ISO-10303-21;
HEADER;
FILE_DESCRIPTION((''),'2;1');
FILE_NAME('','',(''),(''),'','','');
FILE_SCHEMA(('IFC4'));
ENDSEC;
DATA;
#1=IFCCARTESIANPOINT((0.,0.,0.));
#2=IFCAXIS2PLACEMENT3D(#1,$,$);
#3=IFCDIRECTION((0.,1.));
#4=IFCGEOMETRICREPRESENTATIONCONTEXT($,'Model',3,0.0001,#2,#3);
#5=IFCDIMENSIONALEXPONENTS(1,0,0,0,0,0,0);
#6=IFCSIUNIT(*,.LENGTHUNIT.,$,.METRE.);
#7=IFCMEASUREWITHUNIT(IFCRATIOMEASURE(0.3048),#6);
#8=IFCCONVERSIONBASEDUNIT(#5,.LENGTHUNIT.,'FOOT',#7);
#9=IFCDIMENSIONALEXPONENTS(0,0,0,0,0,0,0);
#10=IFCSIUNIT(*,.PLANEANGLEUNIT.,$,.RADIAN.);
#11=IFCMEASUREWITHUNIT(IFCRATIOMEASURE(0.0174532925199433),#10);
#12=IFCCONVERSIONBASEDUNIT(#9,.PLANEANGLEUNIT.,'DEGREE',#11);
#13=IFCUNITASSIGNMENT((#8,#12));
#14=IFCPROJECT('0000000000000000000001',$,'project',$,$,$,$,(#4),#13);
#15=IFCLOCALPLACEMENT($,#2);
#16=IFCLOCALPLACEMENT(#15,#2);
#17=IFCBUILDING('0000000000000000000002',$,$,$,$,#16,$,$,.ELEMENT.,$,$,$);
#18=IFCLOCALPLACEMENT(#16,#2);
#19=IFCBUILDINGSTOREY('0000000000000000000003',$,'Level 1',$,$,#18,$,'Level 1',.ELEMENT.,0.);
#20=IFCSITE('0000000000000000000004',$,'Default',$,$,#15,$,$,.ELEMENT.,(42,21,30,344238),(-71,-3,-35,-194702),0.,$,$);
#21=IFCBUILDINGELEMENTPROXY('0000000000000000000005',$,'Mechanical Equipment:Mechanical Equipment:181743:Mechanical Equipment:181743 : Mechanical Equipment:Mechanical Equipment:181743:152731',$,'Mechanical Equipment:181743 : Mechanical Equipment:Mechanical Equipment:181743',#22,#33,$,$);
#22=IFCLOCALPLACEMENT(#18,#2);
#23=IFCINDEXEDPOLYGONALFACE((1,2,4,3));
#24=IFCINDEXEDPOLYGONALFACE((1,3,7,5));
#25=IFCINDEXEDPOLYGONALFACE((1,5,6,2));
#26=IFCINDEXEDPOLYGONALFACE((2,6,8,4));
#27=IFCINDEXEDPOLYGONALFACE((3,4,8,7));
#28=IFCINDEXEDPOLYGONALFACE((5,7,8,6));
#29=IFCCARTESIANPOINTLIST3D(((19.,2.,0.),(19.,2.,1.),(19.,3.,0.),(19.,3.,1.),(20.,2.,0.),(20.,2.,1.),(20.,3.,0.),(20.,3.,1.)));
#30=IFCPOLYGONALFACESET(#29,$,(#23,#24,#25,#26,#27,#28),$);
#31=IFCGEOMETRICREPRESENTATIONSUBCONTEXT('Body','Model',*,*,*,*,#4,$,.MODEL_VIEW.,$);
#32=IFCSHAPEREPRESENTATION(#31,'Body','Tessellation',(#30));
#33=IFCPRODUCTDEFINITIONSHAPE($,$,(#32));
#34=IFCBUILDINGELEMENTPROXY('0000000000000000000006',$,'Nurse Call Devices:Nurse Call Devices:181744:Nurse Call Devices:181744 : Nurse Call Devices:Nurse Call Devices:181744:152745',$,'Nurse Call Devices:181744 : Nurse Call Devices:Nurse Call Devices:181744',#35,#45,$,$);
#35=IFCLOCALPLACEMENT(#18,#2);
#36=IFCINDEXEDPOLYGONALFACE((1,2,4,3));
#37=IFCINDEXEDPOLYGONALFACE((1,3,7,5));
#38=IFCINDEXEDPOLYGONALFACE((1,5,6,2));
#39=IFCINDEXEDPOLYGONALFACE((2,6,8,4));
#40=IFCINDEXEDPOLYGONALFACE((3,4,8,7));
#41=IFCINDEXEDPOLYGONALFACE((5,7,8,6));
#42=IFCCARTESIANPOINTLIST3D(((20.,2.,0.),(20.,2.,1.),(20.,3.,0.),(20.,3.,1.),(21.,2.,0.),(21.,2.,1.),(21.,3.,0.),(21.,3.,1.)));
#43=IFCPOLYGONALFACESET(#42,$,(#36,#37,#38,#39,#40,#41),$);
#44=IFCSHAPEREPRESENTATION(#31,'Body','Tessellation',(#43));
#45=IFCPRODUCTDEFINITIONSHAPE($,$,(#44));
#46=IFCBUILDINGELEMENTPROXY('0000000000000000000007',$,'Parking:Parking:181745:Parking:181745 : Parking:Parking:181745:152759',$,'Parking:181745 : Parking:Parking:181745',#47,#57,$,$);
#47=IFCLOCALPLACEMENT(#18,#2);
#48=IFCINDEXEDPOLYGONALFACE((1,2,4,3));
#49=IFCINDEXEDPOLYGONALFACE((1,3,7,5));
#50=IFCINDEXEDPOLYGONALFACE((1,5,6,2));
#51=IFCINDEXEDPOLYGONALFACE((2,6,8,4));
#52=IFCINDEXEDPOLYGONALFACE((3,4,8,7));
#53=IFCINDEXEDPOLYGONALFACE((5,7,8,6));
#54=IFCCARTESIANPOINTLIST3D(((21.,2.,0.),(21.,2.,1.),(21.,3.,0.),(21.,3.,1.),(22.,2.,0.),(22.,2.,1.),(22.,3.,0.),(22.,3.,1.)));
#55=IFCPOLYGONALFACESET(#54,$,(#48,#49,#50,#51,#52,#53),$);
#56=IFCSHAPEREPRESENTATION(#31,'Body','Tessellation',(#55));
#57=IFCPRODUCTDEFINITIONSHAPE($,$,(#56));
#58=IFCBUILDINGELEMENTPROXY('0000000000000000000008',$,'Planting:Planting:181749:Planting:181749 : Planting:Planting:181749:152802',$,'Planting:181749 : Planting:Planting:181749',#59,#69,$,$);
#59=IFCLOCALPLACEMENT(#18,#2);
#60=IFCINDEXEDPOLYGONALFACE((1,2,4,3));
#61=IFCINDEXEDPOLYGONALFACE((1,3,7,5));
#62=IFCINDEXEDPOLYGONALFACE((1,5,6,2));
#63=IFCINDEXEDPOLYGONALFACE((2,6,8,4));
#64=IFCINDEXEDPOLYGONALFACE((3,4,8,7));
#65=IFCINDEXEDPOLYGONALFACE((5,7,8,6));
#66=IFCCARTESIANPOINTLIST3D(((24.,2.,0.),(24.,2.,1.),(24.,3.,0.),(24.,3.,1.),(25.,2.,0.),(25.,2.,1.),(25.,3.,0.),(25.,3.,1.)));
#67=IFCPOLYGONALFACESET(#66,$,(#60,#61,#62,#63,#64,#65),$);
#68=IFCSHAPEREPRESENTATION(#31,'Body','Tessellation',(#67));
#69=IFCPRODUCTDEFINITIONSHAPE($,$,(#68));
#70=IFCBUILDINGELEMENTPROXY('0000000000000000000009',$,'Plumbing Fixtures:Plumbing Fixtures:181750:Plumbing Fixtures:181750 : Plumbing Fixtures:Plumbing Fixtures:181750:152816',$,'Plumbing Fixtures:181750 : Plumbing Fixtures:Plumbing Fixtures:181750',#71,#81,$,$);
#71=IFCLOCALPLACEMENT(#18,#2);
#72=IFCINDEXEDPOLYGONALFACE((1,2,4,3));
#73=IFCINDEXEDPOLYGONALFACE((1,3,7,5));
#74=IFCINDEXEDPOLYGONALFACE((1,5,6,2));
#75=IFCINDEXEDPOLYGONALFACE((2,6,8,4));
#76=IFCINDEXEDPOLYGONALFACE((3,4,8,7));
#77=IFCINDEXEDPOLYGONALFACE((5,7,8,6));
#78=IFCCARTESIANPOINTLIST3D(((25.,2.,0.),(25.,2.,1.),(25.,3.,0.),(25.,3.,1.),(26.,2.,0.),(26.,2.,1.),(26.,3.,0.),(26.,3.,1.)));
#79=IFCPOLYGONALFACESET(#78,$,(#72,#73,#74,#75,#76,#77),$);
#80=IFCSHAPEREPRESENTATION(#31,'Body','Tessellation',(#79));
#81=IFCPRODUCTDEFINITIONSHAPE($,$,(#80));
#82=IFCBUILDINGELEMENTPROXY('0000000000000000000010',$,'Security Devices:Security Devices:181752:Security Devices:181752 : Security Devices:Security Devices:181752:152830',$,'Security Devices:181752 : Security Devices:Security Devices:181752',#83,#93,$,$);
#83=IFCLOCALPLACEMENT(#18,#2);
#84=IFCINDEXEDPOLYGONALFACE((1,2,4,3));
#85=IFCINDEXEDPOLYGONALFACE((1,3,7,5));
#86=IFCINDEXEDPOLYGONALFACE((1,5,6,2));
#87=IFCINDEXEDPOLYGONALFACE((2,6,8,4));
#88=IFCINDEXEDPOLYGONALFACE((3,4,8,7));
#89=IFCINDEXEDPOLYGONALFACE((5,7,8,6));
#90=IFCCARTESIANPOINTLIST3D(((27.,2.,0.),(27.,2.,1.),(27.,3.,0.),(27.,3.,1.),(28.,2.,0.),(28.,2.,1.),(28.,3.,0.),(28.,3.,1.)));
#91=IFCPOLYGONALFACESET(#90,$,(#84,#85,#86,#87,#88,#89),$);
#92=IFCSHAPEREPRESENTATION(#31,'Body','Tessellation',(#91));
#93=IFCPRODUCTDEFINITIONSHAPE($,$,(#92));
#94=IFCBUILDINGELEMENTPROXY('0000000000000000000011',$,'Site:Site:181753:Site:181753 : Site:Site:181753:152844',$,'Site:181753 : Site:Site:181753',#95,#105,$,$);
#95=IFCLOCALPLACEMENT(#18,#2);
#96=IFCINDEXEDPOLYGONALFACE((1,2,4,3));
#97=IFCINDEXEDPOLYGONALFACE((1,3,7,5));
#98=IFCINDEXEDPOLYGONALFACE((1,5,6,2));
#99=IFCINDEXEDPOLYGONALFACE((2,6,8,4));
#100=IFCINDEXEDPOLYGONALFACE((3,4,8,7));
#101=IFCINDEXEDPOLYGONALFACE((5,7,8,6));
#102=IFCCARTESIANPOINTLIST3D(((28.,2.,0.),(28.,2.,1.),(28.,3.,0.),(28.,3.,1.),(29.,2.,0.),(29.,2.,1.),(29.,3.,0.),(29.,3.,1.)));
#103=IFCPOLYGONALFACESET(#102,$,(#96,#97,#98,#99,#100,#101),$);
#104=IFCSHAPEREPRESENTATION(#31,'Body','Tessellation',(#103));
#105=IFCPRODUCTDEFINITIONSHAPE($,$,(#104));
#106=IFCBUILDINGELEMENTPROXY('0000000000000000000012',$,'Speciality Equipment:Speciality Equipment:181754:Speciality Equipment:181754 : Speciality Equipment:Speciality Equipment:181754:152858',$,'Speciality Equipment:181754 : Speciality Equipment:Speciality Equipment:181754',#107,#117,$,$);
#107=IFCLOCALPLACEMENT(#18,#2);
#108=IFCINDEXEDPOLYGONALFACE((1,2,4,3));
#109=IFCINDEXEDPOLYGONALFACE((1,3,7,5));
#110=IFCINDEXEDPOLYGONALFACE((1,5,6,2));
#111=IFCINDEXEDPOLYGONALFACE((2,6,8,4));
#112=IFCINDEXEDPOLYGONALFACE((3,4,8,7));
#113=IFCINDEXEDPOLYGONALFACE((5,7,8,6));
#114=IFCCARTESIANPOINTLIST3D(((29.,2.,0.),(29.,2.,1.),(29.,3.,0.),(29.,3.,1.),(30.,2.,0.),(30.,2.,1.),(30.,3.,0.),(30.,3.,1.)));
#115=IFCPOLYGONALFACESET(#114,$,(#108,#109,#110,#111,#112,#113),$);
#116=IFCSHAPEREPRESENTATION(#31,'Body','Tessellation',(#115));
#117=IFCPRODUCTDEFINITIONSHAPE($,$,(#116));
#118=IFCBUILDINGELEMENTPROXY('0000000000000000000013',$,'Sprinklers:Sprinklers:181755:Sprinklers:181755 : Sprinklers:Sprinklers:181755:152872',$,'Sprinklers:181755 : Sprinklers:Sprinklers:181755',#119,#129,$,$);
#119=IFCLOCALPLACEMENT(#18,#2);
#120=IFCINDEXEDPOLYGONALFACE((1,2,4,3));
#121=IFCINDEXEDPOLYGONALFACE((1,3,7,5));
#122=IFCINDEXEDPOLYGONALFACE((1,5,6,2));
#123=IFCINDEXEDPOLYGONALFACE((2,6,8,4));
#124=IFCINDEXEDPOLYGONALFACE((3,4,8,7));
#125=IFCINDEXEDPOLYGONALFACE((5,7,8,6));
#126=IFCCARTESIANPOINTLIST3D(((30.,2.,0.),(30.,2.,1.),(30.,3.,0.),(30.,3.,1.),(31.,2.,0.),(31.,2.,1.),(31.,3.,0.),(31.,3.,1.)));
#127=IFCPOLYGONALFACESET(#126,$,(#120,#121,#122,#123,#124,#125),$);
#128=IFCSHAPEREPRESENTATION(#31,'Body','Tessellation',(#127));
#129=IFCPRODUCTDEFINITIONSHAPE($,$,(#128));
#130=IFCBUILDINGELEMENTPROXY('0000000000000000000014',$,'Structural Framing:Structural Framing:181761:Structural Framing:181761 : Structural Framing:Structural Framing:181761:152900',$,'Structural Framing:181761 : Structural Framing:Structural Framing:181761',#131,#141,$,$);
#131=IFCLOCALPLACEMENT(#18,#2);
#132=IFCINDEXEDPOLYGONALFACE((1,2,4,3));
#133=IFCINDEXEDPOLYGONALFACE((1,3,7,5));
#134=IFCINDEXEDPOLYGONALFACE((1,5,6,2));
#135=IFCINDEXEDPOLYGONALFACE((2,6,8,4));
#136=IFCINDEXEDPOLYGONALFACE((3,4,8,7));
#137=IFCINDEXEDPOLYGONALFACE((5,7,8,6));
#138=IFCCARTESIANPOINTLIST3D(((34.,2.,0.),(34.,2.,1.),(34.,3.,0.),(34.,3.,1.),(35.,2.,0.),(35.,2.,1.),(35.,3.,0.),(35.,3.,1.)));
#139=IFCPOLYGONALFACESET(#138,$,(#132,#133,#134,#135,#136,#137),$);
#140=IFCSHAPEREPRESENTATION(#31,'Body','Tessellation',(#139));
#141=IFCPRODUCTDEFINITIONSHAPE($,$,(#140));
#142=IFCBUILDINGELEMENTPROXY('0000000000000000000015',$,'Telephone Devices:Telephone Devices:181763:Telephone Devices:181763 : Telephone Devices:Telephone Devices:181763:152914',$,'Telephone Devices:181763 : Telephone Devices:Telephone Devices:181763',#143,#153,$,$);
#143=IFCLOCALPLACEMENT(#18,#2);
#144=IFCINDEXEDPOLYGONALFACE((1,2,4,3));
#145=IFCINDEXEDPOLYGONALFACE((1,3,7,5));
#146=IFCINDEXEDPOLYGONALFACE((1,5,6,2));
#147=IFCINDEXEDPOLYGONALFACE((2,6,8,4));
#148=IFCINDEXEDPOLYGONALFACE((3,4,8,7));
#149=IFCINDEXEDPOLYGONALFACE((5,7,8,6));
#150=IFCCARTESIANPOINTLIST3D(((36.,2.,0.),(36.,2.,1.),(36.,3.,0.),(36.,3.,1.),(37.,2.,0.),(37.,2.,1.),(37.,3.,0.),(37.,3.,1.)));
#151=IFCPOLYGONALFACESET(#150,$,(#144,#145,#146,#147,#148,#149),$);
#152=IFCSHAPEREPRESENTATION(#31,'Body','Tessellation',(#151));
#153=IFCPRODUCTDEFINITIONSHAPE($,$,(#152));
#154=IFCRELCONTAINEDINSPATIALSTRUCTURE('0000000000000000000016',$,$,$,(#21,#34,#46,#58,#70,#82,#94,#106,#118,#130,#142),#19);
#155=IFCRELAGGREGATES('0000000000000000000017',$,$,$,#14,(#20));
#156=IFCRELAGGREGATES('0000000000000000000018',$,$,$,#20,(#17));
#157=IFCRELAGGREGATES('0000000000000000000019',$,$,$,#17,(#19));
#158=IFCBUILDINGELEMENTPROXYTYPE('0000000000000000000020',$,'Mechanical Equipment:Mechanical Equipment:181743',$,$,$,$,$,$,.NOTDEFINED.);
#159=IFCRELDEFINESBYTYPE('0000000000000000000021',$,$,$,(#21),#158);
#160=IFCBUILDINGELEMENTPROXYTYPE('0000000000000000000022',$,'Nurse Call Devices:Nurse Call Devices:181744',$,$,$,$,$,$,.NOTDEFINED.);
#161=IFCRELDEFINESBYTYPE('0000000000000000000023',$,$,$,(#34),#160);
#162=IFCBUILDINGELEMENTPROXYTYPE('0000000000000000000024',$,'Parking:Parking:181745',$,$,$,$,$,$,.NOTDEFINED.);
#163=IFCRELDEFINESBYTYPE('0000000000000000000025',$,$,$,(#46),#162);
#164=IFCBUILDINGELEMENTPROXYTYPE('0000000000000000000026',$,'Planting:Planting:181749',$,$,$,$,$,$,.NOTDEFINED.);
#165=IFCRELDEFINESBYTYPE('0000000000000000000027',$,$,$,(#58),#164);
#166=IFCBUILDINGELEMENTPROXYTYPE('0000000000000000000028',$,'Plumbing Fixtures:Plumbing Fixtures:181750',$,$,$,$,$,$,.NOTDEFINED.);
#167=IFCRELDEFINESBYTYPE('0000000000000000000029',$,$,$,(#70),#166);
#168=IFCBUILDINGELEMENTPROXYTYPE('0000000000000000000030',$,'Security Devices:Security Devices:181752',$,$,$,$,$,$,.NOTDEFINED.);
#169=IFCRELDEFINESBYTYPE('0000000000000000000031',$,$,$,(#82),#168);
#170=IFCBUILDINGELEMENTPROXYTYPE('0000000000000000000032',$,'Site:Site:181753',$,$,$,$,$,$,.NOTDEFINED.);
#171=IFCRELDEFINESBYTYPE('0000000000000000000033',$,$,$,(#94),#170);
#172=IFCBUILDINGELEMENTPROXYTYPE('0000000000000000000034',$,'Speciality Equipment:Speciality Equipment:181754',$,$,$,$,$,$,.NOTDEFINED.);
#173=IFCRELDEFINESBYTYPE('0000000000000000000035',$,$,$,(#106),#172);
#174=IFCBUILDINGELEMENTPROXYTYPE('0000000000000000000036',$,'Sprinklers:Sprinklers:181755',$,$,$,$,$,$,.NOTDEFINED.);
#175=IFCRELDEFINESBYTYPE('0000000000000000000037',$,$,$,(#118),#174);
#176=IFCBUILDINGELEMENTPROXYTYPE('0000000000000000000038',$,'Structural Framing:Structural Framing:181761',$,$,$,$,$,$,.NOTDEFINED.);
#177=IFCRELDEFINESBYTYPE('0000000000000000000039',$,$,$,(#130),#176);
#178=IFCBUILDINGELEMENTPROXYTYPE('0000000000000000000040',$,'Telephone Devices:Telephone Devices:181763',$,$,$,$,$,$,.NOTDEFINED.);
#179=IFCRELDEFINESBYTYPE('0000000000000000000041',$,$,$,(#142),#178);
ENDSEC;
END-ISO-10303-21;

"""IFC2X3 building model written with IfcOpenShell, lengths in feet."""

from ifc_helpers import new_model, entity, si_unit, converted_unit, direction, frame, frame_2d, origin, place, context, subcontext, project, spatial, rectangle, extrude, source, transform, mapped, type_object, type_shapes, element, save


model = new_model("IFC2X3")

# Units and contexts
model_context = context("Model", 3, precision=0.0001, world=origin(), true_north=direction((0.0, 1.0)))
body_context = subcontext(model_context, "Body", "Model", "MODEL_VIEW")
ifc_project = project(units=[converted_unit("LENGTHUNIT", "FOOT", entity("IfcRatioMeasure", 0.3048), si_unit("LENGTHUNIT", "METRE"), dimensions=[1, 0, 0, 0, 0, 0, 0]), converted_unit("PLANEANGLEUNIT", "DEGREE", entity("IfcRatioMeasure", 0.0174532925199433), si_unit("PLANEANGLEUNIT", "RADIAN"), dimensions=[0, 0, 0, 0, 0, 0, 0])], contexts=[model_context])

# Site, building, storey
site_placement = place(None, origin())
site = spatial("IfcSite", under=ifc_project, at=site_placement, Name="Default", CompositionType="ELEMENT", RefLatitude=(42, 21, 30, 344238), RefLongitude=(-71, -3, -35, -194702), RefElevation=0.0)
building_placement = place(site_placement, origin())
building = spatial("IfcBuilding", under=site, at=building_placement, CompositionType="ELEMENT")
storey_placement = place(building_placement, origin())
storey = spatial("IfcBuildingStorey", under=building, at=storey_placement, Name="Level 1", LongName="Level 1", CompositionType="ELEMENT", Elevation=0.0)

# Building element proxies
building_element_proxy_type_1 = type_object("IfcBuildingElementProxyType", Name="Mechanical Equipment:Mechanical Equipment:181743", PredefinedType="NOTDEFINED")
shared_shape_1 = source(origin(), body_context, "Body", "SweptSolid", [
    extrude(rectangle(XDim=1.0, YDim=1.0, at=frame_2d((0.0, 0.0), x_axis=(1.0, 0.0))), frame((19.5, 2.5, 0.0), z_axis=(0.0, 0.0, 1.0), x_axis=(-1.0, 0.0, 0.0)), (0.0, 0.0, 1.0), 1.0),
])
type_shapes(building_element_proxy_type_1, [shared_shape_1])
proxy_1_placement = place(storey_placement, origin())
element("IfcBuildingElementProxy", 1, at=proxy_1_placement, inside=storey, type_object=building_element_proxy_type_1, Name="Mechanical Equipment:Mechanical Equipment:181743:Mechanical Equipment:181743 : Mechanical Equipment:Mechanical Equipment:181743:152731", ObjectType="Mechanical Equipment:181743 : Mechanical Equipment:Mechanical Equipment:181743", context=body_context, shape_type="MappedRepresentation", body=[
    mapped(shared_shape_1, transform((0.0, 0.0, 0.0), scale=1.0)),
])
building_element_proxy_type_2 = type_object("IfcBuildingElementProxyType", Name="Nurse Call Devices:Nurse Call Devices:181744", PredefinedType="NOTDEFINED")
shared_shape_2 = source(origin(), body_context, "Body", "SweptSolid", [
    extrude(rectangle(XDim=1.0, YDim=1.0, at=frame_2d((0.0, 0.0), x_axis=(1.0, 0.0))), frame((20.5, 2.5, 0.0), z_axis=(0.0, 0.0, 1.0), x_axis=(-1.0, 0.0, 0.0)), (0.0, 0.0, 1.0), 1.0),
])
type_shapes(building_element_proxy_type_2, [shared_shape_2])
proxy_2_placement = place(storey_placement, origin())
element("IfcBuildingElementProxy", 2, at=proxy_2_placement, inside=storey, type_object=building_element_proxy_type_2, Name="Nurse Call Devices:Nurse Call Devices:181744:Nurse Call Devices:181744 : Nurse Call Devices:Nurse Call Devices:181744:152745", ObjectType="Nurse Call Devices:181744 : Nurse Call Devices:Nurse Call Devices:181744", context=body_context, shape_type="MappedRepresentation", body=[
    mapped(shared_shape_2, transform((0.0, 0.0, 0.0), scale=1.0)),
])
building_element_proxy_type_3 = type_object("IfcBuildingElementProxyType", Name="Parking:Parking:181745", PredefinedType="NOTDEFINED")
shared_shape_3 = source(origin(), body_context, "Body", "SweptSolid", [
    extrude(rectangle(XDim=1.0, YDim=1.0, at=frame_2d((0.0, 0.0), x_axis=(1.0, 0.0))), frame((21.5, 2.5, 0.0), z_axis=(0.0, 0.0, 1.0), x_axis=(-1.0, 0.0, 0.0)), (0.0, 0.0, 1.0), 1.0),
])
type_shapes(building_element_proxy_type_3, [shared_shape_3])
proxy_3_placement = place(storey_placement, origin())
element("IfcBuildingElementProxy", 3, at=proxy_3_placement, inside=storey, type_object=building_element_proxy_type_3, Name="Parking:Parking:181745:Parking:181745 : Parking:Parking:181745:152759", ObjectType="Parking:181745 : Parking:Parking:181745", context=body_context, shape_type="MappedRepresentation", body=[
    mapped(shared_shape_3, transform((0.0, 0.0, 0.0), scale=1.0)),
])
building_element_proxy_type_4 = type_object("IfcBuildingElementProxyType", Name="Planting:Planting:181749", PredefinedType="NOTDEFINED")
shared_shape_4 = source(origin(), body_context, "Body", "SweptSolid", [
    extrude(rectangle(XDim=1.0, YDim=1.0, at=frame_2d((0.0, 0.0), x_axis=(1.0, 0.0))), frame((24.5, 2.5, 0.0), z_axis=(0.0, 0.0, 1.0), x_axis=(-1.0, 0.0, 0.0)), (0.0, 0.0, 1.0), 1.0),
])
type_shapes(building_element_proxy_type_4, [shared_shape_4])
proxy_4_placement = place(storey_placement, origin())
element("IfcBuildingElementProxy", 4, at=proxy_4_placement, inside=storey, type_object=building_element_proxy_type_4, Name="Planting:Planting:181749:Planting:181749 : Planting:Planting:181749:152802", ObjectType="Planting:181749 : Planting:Planting:181749", context=body_context, shape_type="MappedRepresentation", body=[
    mapped(shared_shape_4, transform((0.0, 0.0, 0.0), scale=1.0)),
])
building_element_proxy_type_5 = type_object("IfcBuildingElementProxyType", Name="Plumbing Fixtures:Plumbing Fixtures:181750", PredefinedType="NOTDEFINED")
shared_shape_5 = source(origin(), body_context, "Body", "SweptSolid", [
    extrude(rectangle(XDim=1.0, YDim=1.0, at=frame_2d((0.0, 0.0), x_axis=(1.0, 0.0))), frame((25.5, 2.5, 0.0), z_axis=(0.0, 0.0, 1.0), x_axis=(-1.0, 0.0, 0.0)), (0.0, 0.0, 1.0), 1.0),
])
type_shapes(building_element_proxy_type_5, [shared_shape_5])
proxy_5_placement = place(storey_placement, origin())
element("IfcBuildingElementProxy", 5, at=proxy_5_placement, inside=storey, type_object=building_element_proxy_type_5, Name="Plumbing Fixtures:Plumbing Fixtures:181750:Plumbing Fixtures:181750 : Plumbing Fixtures:Plumbing Fixtures:181750:152816", ObjectType="Plumbing Fixtures:181750 : Plumbing Fixtures:Plumbing Fixtures:181750", context=body_context, shape_type="MappedRepresentation", body=[
    mapped(shared_shape_5, transform((0.0, 0.0, 0.0), scale=1.0)),
])
building_element_proxy_type_6 = type_object("IfcBuildingElementProxyType", Name="Security Devices:Security Devices:181752", PredefinedType="NOTDEFINED")
shared_shape_6 = source(origin(), body_context, "Body", "SweptSolid", [
    extrude(rectangle(XDim=1.0, YDim=1.0, at=frame_2d((0.0, 0.0), x_axis=(1.0, 0.0))), frame((27.5, 2.5, 0.0), z_axis=(0.0, 0.0, 1.0), x_axis=(-1.0, 0.0, 0.0)), (0.0, 0.0, 1.0), 1.0),
])
type_shapes(building_element_proxy_type_6, [shared_shape_6])
proxy_6_placement = place(storey_placement, origin())
element("IfcBuildingElementProxy", 6, at=proxy_6_placement, inside=storey, type_object=building_element_proxy_type_6, Name="Security Devices:Security Devices:181752:Security Devices:181752 : Security Devices:Security Devices:181752:152830", ObjectType="Security Devices:181752 : Security Devices:Security Devices:181752", context=body_context, shape_type="MappedRepresentation", body=[
    mapped(shared_shape_6, transform((0.0, 0.0, 0.0), scale=1.0)),
])
building_element_proxy_type_7 = type_object("IfcBuildingElementProxyType", Name="Site:Site:181753", PredefinedType="NOTDEFINED")
shared_shape_7 = source(origin(), body_context, "Body", "SweptSolid", [
    extrude(rectangle(XDim=1.0, YDim=1.0, at=frame_2d((0.0, 0.0), x_axis=(1.0, 0.0))), frame((28.5, 2.5, 0.0), z_axis=(0.0, 0.0, 1.0), x_axis=(-1.0, 0.0, 0.0)), (0.0, 0.0, 1.0), 1.0),
])
type_shapes(building_element_proxy_type_7, [shared_shape_7])
proxy_7_placement = place(storey_placement, origin())
element("IfcBuildingElementProxy", 7, at=proxy_7_placement, inside=storey, type_object=building_element_proxy_type_7, Name="Site:Site:181753:Site:181753 : Site:Site:181753:152844", ObjectType="Site:181753 : Site:Site:181753", context=body_context, shape_type="MappedRepresentation", body=[
    mapped(shared_shape_7, transform((0.0, 0.0, 0.0), scale=1.0)),
])
building_element_proxy_type_8 = type_object("IfcBuildingElementProxyType", Name="Speciality Equipment:Speciality Equipment:181754", PredefinedType="NOTDEFINED")
shared_shape_8 = source(origin(), body_context, "Body", "SweptSolid", [
    extrude(rectangle(XDim=1.0, YDim=1.0, at=frame_2d((0.0, 0.0), x_axis=(1.0, 0.0))), frame((29.5, 2.5, 0.0), z_axis=(0.0, 0.0, 1.0), x_axis=(-1.0, 0.0, 0.0)), (0.0, 0.0, 1.0), 1.0),
])
type_shapes(building_element_proxy_type_8, [shared_shape_8])
proxy_8_placement = place(storey_placement, origin())
element("IfcBuildingElementProxy", 8, at=proxy_8_placement, inside=storey, type_object=building_element_proxy_type_8, Name="Speciality Equipment:Speciality Equipment:181754:Speciality Equipment:181754 : Speciality Equipment:Speciality Equipment:181754:152858", ObjectType="Speciality Equipment:181754 : Speciality Equipment:Speciality Equipment:181754", context=body_context, shape_type="MappedRepresentation", body=[
    mapped(shared_shape_8, transform((0.0, 0.0, 0.0), scale=1.0)),
])
building_element_proxy_type_9 = type_object("IfcBuildingElementProxyType", Name="Sprinklers:Sprinklers:181755", PredefinedType="NOTDEFINED")
shared_shape_9 = source(origin(), body_context, "Body", "SweptSolid", [
    extrude(rectangle(XDim=1.0, YDim=1.0, at=frame_2d((0.0, 0.0), x_axis=(1.0, 0.0))), frame((30.5, 2.5, 0.0), z_axis=(0.0, 0.0, 1.0), x_axis=(-1.0, 0.0, 0.0)), (0.0, 0.0, 1.0), 1.0),
])
type_shapes(building_element_proxy_type_9, [shared_shape_9])
proxy_9_placement = place(storey_placement, origin())
element("IfcBuildingElementProxy", 9, at=proxy_9_placement, inside=storey, type_object=building_element_proxy_type_9, Name="Sprinklers:Sprinklers:181755:Sprinklers:181755 : Sprinklers:Sprinklers:181755:152872", ObjectType="Sprinklers:181755 : Sprinklers:Sprinklers:181755", context=body_context, shape_type="MappedRepresentation", body=[
    mapped(shared_shape_9, transform((0.0, 0.0, 0.0), scale=1.0)),
])
building_element_proxy_type_10 = type_object("IfcBuildingElementProxyType", Name="Structural Framing:Structural Framing:181761", PredefinedType="NOTDEFINED")
shared_shape_10 = source(origin(), body_context, "Body", "SweptSolid", [
    extrude(rectangle(XDim=1.0, YDim=1.0, at=frame_2d((0.0, 0.0), x_axis=(1.0, 0.0))), frame((34.5, 2.5, 0.0), z_axis=(0.0, 0.0, 1.0), x_axis=(-1.0, 0.0, 0.0)), (0.0, 0.0, 1.0), 1.0),
])
type_shapes(building_element_proxy_type_10, [shared_shape_10])
proxy_10_placement = place(storey_placement, origin())
element("IfcBuildingElementProxy", 10, at=proxy_10_placement, inside=storey, type_object=building_element_proxy_type_10, Name="Structural Framing:Structural Framing:181761:Structural Framing:181761 : Structural Framing:Structural Framing:181761:152900", ObjectType="Structural Framing:181761 : Structural Framing:Structural Framing:181761", context=body_context, shape_type="MappedRepresentation", body=[
    mapped(shared_shape_10, transform((0.0, 0.0, 0.0), scale=1.0)),
])
building_element_proxy_type_11 = type_object("IfcBuildingElementProxyType", Name="Telephone Devices:Telephone Devices:181763", PredefinedType="NOTDEFINED")
shared_shape_11 = source(origin(), body_context, "Body", "SweptSolid", [
    extrude(rectangle(XDim=1.0, YDim=1.0, at=frame_2d((0.0, 0.0), x_axis=(1.0, 0.0))), frame((36.5, 2.5, 0.0), z_axis=(0.0, 0.0, 1.0), x_axis=(-1.0, 0.0, 0.0)), (0.0, 0.0, 1.0), 1.0),
])
type_shapes(building_element_proxy_type_11, [shared_shape_11])
proxy_11_placement = place(storey_placement, origin())
element("IfcBuildingElementProxy", 11, at=proxy_11_placement, inside=storey, type_object=building_element_proxy_type_11, Name="Telephone Devices:Telephone Devices:181763:Telephone Devices:181763 : Telephone Devices:Telephone Devices:181763:152914", ObjectType="Telephone Devices:181763 : Telephone Devices:Telephone Devices:181763", context=body_context, shape_type="MappedRepresentation", body=[
    mapped(shared_shape_11, transform((0.0, 0.0, 0.0), scale=1.0)),
])

save(model, "model.ifc")
